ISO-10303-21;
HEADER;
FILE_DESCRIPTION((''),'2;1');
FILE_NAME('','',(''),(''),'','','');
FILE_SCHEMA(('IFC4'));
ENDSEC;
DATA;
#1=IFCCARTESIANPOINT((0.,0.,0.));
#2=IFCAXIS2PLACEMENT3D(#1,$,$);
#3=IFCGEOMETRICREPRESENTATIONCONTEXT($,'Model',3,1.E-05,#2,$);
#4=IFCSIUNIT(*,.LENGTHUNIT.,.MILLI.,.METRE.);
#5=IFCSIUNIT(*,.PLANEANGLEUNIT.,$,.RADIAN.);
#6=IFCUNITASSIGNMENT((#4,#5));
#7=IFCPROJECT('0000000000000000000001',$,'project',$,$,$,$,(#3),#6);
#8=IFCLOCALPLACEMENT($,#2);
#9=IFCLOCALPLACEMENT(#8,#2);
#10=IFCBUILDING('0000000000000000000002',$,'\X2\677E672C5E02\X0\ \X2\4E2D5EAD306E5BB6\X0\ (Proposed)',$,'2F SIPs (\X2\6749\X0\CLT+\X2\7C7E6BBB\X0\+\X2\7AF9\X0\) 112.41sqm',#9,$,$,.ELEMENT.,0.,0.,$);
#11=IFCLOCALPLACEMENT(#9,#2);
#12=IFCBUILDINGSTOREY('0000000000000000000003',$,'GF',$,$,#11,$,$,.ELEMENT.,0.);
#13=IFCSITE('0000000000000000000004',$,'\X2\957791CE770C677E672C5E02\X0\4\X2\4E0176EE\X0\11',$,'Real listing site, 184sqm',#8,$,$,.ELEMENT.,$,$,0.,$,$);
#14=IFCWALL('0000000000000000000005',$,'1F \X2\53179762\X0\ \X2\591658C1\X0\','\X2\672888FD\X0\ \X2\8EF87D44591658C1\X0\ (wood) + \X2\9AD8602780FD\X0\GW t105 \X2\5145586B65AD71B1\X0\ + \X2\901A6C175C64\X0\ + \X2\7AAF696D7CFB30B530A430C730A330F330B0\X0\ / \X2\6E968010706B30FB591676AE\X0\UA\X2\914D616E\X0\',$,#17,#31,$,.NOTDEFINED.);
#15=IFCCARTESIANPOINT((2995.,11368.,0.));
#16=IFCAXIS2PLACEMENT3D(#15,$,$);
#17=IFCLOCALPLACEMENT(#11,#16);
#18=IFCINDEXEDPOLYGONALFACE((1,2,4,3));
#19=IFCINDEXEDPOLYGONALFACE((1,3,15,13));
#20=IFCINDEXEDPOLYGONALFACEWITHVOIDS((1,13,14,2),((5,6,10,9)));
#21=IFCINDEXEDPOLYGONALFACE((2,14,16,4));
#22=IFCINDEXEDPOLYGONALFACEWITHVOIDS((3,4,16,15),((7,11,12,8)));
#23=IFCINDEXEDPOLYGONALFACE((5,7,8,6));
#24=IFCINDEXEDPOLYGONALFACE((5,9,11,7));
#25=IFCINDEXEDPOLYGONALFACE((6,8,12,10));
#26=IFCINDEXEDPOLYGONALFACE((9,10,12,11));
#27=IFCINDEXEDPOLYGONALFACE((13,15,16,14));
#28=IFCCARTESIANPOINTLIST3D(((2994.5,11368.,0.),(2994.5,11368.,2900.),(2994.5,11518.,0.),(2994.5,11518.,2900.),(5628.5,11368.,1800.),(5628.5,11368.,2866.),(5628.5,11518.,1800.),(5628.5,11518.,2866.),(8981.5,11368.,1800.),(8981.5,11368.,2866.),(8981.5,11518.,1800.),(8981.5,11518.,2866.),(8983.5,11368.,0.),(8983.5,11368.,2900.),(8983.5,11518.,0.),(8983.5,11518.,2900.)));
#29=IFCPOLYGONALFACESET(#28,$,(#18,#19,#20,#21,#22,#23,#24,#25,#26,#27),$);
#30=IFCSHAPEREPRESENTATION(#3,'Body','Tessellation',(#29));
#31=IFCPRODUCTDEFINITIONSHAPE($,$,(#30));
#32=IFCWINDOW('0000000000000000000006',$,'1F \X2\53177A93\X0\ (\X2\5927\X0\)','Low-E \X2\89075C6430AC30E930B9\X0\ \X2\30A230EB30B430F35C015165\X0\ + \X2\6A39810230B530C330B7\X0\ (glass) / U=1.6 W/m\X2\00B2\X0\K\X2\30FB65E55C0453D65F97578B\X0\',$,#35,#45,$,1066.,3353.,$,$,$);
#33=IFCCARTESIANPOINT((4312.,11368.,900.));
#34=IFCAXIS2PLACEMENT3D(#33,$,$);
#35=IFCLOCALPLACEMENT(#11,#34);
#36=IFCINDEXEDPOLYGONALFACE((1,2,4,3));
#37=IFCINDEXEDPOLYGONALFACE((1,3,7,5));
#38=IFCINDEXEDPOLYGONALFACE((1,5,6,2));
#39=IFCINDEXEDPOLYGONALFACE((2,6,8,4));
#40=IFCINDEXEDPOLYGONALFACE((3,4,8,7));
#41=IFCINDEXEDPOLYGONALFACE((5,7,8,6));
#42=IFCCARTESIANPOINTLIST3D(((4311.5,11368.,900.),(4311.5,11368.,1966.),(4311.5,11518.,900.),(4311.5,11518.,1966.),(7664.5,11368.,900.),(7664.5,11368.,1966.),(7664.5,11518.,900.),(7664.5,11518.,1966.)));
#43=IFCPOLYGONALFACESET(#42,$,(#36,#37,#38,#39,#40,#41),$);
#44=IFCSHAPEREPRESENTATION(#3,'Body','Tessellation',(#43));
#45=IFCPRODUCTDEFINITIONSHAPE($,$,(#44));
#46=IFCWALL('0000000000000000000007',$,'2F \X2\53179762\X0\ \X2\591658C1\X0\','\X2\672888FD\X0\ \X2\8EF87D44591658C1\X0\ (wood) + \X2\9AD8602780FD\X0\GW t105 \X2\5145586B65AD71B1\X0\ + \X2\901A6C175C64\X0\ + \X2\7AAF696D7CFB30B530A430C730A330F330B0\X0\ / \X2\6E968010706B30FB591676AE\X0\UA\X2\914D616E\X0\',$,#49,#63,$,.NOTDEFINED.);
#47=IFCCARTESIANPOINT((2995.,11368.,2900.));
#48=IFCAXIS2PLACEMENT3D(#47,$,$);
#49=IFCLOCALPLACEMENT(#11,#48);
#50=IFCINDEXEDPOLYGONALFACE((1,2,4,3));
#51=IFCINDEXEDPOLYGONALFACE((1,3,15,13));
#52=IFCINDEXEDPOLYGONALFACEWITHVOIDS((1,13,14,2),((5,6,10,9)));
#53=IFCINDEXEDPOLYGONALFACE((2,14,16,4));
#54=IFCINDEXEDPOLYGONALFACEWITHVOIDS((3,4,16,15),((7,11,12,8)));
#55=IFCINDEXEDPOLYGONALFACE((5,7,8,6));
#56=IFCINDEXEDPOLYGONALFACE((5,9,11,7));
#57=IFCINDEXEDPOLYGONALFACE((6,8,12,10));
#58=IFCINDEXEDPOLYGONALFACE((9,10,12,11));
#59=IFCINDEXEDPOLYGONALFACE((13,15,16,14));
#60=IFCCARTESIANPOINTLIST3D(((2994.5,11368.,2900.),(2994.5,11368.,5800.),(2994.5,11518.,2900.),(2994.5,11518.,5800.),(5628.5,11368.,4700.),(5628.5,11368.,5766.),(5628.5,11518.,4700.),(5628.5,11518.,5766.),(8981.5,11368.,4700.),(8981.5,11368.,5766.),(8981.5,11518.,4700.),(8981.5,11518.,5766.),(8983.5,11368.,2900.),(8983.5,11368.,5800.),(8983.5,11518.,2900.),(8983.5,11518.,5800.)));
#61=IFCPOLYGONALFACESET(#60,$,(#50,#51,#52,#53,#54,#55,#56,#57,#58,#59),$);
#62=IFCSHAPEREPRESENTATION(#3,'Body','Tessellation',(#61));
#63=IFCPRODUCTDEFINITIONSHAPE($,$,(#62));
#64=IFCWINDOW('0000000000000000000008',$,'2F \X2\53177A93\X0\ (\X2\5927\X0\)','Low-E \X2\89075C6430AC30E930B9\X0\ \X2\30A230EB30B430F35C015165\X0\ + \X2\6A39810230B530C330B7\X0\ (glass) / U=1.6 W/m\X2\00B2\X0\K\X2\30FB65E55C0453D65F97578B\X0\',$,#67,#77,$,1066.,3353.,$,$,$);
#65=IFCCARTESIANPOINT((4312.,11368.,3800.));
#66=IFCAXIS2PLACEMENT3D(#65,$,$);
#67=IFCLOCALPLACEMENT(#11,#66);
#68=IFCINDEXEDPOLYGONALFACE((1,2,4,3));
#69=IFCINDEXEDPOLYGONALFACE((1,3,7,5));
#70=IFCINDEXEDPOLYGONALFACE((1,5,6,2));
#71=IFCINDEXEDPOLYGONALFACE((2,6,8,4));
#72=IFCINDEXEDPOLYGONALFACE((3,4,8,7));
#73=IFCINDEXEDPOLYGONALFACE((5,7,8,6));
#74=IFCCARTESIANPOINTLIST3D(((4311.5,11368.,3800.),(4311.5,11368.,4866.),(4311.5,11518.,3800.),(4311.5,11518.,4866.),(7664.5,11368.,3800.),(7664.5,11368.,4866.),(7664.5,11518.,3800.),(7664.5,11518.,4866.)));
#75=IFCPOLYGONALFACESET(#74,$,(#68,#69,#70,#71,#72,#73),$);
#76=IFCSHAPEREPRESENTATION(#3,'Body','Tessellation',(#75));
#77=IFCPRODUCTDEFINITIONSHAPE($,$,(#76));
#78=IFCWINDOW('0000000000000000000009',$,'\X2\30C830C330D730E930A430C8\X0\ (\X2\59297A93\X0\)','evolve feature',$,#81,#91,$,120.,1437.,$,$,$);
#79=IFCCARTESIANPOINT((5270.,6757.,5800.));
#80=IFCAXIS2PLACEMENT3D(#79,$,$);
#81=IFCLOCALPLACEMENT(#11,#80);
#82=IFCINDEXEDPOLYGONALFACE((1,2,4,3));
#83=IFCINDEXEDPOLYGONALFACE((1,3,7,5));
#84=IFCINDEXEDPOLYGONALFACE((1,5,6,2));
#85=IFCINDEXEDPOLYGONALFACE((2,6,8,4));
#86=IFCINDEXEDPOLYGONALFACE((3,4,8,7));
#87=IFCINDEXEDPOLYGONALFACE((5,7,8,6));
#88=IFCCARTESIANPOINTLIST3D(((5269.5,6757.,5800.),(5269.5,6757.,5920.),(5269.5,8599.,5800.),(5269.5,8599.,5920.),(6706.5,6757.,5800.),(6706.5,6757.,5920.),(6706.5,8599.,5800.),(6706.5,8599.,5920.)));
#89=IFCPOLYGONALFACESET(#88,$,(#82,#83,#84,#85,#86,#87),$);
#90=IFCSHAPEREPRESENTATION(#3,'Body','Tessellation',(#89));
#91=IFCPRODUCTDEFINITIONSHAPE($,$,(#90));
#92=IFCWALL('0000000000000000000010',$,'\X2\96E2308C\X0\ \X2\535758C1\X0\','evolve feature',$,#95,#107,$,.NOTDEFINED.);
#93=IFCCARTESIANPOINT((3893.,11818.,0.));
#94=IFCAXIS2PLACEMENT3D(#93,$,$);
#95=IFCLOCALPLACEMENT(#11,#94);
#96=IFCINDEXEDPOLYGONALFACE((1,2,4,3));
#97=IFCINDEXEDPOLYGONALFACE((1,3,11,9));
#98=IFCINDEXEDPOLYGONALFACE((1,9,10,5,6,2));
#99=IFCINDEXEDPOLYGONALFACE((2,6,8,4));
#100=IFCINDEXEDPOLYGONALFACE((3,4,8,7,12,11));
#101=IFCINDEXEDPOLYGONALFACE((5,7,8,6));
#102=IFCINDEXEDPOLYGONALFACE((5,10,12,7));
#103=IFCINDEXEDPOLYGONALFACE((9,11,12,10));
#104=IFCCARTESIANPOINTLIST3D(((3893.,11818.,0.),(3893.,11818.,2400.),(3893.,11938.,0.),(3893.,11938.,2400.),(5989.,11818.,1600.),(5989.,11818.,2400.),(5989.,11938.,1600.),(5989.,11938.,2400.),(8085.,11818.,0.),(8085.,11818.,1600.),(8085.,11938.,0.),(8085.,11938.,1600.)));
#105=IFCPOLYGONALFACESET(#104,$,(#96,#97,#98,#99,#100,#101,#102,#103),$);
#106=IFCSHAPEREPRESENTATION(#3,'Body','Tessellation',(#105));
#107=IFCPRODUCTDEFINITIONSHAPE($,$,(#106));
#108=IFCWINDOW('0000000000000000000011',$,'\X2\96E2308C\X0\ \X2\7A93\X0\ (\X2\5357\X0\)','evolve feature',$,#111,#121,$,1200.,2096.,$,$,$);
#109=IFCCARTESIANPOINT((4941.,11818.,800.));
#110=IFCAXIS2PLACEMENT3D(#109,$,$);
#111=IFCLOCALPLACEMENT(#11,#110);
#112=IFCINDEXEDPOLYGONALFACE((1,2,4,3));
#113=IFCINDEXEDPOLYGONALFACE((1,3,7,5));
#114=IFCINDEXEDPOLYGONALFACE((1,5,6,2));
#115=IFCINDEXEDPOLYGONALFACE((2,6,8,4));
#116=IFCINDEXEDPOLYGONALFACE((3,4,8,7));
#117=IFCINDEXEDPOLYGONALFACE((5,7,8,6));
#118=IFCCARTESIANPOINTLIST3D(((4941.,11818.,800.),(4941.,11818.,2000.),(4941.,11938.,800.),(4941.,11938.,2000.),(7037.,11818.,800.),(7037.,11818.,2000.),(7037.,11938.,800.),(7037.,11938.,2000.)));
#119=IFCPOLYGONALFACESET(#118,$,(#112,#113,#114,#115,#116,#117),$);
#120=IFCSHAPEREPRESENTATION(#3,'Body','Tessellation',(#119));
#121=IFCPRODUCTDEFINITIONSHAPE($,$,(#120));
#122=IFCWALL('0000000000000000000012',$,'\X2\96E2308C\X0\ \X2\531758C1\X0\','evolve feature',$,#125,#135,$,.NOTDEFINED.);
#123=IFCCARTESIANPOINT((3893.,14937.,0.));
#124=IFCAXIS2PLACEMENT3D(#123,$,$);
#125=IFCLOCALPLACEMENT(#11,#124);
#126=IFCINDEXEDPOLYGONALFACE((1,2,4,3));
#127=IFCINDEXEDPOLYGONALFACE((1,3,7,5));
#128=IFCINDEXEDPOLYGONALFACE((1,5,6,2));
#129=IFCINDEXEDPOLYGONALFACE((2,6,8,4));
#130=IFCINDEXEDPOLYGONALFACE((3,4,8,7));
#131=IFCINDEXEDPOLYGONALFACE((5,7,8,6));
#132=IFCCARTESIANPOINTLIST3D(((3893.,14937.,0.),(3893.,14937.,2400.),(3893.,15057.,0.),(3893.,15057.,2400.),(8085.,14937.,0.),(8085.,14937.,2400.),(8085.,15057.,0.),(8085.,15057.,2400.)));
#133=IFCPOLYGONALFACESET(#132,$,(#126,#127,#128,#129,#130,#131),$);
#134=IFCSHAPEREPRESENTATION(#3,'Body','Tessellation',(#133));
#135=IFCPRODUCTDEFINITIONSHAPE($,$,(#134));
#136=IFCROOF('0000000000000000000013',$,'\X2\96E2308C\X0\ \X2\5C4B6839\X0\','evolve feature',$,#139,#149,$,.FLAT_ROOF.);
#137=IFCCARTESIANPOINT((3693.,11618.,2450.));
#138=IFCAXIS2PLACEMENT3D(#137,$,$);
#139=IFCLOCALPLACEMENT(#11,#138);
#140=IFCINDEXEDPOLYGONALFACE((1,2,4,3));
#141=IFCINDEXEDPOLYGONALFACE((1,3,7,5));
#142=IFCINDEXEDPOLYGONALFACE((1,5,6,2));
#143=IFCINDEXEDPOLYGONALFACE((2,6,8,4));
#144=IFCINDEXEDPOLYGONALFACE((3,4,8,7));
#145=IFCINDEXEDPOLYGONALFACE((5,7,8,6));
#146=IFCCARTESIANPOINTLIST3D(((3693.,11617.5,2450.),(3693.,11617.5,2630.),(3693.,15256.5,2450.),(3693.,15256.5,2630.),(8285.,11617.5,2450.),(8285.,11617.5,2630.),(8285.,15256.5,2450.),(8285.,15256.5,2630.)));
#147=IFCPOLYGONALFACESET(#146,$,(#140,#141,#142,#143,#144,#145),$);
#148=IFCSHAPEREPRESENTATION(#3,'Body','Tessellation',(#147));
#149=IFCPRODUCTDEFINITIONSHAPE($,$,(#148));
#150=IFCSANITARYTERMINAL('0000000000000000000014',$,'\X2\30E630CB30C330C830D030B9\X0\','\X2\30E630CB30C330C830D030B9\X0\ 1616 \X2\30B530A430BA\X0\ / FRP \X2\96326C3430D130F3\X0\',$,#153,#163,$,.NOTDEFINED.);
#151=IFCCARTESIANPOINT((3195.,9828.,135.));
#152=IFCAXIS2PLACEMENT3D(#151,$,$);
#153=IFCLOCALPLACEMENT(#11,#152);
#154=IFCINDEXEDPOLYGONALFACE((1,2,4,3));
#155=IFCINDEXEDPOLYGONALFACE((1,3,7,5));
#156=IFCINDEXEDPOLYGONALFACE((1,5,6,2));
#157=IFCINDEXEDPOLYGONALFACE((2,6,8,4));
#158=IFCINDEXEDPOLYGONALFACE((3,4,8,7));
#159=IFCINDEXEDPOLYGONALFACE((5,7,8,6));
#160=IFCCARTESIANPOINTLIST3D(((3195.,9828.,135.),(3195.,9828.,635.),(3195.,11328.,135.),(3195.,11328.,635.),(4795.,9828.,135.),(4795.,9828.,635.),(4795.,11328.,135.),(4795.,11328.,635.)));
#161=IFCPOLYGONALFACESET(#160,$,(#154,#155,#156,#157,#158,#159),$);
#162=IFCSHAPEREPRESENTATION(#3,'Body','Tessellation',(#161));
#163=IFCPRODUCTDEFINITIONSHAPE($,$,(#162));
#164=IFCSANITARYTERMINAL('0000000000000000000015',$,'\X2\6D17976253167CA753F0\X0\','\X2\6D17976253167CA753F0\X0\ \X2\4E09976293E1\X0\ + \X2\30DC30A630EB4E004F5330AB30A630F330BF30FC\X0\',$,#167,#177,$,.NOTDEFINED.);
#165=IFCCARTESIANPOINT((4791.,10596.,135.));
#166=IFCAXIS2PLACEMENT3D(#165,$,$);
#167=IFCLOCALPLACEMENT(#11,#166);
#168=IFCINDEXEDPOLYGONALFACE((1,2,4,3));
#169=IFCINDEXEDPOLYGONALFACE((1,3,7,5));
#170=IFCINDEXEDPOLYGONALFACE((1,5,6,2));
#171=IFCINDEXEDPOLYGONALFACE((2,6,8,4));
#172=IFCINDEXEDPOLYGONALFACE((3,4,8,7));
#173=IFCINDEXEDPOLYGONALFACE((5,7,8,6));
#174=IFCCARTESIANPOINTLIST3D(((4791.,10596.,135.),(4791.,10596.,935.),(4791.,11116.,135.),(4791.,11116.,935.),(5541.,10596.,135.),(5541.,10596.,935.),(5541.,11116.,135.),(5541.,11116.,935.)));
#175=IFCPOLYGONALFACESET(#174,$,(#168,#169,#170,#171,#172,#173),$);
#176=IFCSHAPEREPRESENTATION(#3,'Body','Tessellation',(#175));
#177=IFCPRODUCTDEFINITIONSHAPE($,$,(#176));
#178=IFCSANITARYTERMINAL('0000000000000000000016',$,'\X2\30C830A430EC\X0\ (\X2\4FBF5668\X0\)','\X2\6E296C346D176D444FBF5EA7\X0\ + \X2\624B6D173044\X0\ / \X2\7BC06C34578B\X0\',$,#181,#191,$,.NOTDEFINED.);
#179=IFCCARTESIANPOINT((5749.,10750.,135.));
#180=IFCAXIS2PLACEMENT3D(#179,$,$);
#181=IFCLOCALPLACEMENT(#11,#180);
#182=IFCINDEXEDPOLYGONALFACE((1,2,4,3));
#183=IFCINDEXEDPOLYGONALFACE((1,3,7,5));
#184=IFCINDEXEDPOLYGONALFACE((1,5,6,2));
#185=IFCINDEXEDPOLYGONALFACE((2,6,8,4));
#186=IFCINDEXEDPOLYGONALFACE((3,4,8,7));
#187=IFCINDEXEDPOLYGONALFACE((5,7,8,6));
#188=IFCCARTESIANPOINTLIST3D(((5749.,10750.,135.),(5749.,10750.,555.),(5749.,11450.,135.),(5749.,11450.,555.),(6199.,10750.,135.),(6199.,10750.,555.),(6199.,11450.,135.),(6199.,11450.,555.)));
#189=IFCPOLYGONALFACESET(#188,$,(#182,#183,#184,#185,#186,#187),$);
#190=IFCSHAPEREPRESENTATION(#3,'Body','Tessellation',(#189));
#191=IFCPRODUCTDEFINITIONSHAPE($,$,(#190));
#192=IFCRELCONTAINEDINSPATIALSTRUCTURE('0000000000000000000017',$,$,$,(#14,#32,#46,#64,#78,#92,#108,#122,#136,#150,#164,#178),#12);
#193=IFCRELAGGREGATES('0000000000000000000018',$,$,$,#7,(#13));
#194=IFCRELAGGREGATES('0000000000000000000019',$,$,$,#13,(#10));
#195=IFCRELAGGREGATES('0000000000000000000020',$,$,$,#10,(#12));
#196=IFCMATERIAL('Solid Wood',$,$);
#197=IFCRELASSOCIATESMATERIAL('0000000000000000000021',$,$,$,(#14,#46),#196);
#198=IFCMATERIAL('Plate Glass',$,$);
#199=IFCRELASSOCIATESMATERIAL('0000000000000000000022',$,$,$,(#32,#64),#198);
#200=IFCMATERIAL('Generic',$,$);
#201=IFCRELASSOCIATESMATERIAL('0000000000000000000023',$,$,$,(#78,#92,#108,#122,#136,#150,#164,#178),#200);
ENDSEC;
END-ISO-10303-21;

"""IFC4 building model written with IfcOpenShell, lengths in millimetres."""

from ifc_helpers import new_model, si_unit, frame, frame_2d, origin, place, context, project, spatial, rectangle, extrude, material, element, fill, save


model = new_model("IFC4")

# Units and contexts
model_context = context("Model", 3, precision=1e-05, world=origin())
ifc_project = project(units=[si_unit("LENGTHUNIT", "METRE", prefix="MILLI"), si_unit("PLANEANGLEUNIT", "RADIAN")], contexts=[model_context])

# Site, building, storey
site_placement = place(None, origin())
site = spatial("IfcSite", under=ifc_project, at=site_placement, Name="長野県松本市4丁目11", ObjectType="Real listing site, 184sqm", CompositionType="ELEMENT", RefElevation=0.0)
building_placement = place(site_placement, origin())
building = spatial("IfcBuilding", under=site, at=building_placement, Name="松本市 中庭の家 (Proposed)", ObjectType="2F SIPs (杉CLT+籾殻+竹) 112.41sqm", CompositionType="ELEMENT", ElevationOfRefHeight=0.0, ElevationOfTerrain=0.0)
storey_placement = place(building_placement, origin())
storey = spatial("IfcBuildingStorey", under=building, at=storey_placement, Name="GF", CompositionType="ELEMENT", Elevation=0.0)

# Shared definitions
ifc_material_1 = material(Name="Generic")

# Wall, opening, window
ifc_material_2 = material(Name="Solid Wood")
wall_1_placement = place(storey_placement, frame((2995.0, 11368.0, 0.0)))
wall_1 = element("IfcWall", 1, at=wall_1_placement, inside=storey, material=ifc_material_2, Name="1F 北面 外壁", Description="木製 軸組外壁 (wood) + 高性能GW t105 充填断熱 + 通気層 + 窯業系サイディング / 準耐火・外皮UA配慮", PredefinedType="NOTDEFINED", context=model_context, shape_type="SweptSolid", body=[
    extrude(rectangle(XDim=5989.0, YDim=150.0, at=frame_2d((2994.0, 75.0))), frame((2995.0, 11368.0, 0.0)), (0.0, 0.0, 1.0), 2900.0),
])
opening_1_placement = place(storey_placement, frame((4312.0, 11368.0, 900.0)))
opening_1 = element("IfcOpeningElement", 2, at=opening_1_placement, cuts=wall_1, PredefinedType="NOTDEFINED", context=model_context, shape_type="SweptSolid", body=[
    extrude(rectangle(XDim=3353.0, YDim=150.0, at=frame_2d((1676.0, 75.0))), frame((4312.0, 11368.0, 900.0)), (0.0, 0.0, 1.0), 1066.0),
])
ifc_material_3 = material(Name="Plate Glass")
window_1_placement = place(storey_placement, frame((4312.0, 11368.0, 900.0)))
window_1 = element("IfcWindow", 3, at=window_1_placement, inside=storey, material=ifc_material_3, Name="1F 北窓 (大)", Description="Low-E 複層ガラス アルゴン封入 + 樹脂サッシ (glass) / U=1.6 W/m²K・日射取得型", OverallHeight=1066.0, OverallWidth=3353.0, context=model_context, shape_type="SweptSolid", body=[
    extrude(rectangle(XDim=3353.0, YDim=150.0, at=frame_2d((1676.0, 75.0))), frame((4312.0, 11368.0, 900.0)), (0.0, 0.0, 1.0), 1066.0),
])
fill(opening_1, window_1)

# Wall, opening, window
wall_2_placement = place(storey_placement, frame((2995.0, 11368.0, 2900.0)))
wall_2 = element("IfcWall", 4, at=wall_2_placement, inside=storey, material=ifc_material_2, Name="2F 北面 外壁", Description="木製 軸組外壁 (wood) + 高性能GW t105 充填断熱 + 通気層 + 窯業系サイディング / 準耐火・外皮UA配慮", PredefinedType="NOTDEFINED", context=model_context, shape_type="SweptSolid", body=[
    extrude(rectangle(XDim=5989.0, YDim=150.0, at=frame_2d((2994.0, 75.0))), frame((2995.0, 11368.0, 2900.0)), (0.0, 0.0, 1.0), 2900.0),
])
opening_2_placement = place(storey_placement, frame((4312.0, 11368.0, 3800.0)))
opening_2 = element("IfcOpeningElement", 5, at=opening_2_placement, cuts=wall_2, PredefinedType="NOTDEFINED", context=model_context, shape_type="SweptSolid", body=[
    extrude(rectangle(XDim=3353.0, YDim=150.0, at=frame_2d((1676.0, 75.0))), frame((4312.0, 11368.0, 3800.0)), (0.0, 0.0, 1.0), 1066.0),
])
window_2_placement = place(storey_placement, frame((4312.0, 11368.0, 3800.0)))
window_2 = element("IfcWindow", 6, at=window_2_placement, inside=storey, material=ifc_material_3, Name="2F 北窓 (大)", Description="Low-E 複層ガラス アルゴン封入 + 樹脂サッシ (glass) / U=1.6 W/m²K・日射取得型", OverallHeight=1066.0, OverallWidth=3353.0, context=model_context, shape_type="SweptSolid", body=[
    extrude(rectangle(XDim=3353.0, YDim=150.0, at=frame_2d((1676.0, 75.0))), frame((4312.0, 11368.0, 3800.0)), (0.0, 0.0, 1.0), 1066.0),
])
fill(opening_2, window_2)

# Window
window_3_placement = place(storey_placement, frame((5270.0, 6757.0, 5800.0)))
element("IfcWindow", 7, at=window_3_placement, inside=storey, material=ifc_material_1, Name="トップライト (天窓)", Description="evolve feature", OverallHeight=120.0, OverallWidth=1437.0, context=model_context, shape_type="SweptSolid", body=[
    extrude(rectangle(XDim=1437.0, YDim=1842.0, at=frame_2d((718.0, 921.0))), frame((5270.0, 6757.0, 5800.0)), (0.0, 0.0, 1.0), 120.0),
])

# Wall, opening, window
wall_3_placement = place(storey_placement, frame((3893.0, 11818.0, 0.0)))
wall_3 = element("IfcWall", 8, at=wall_3_placement, inside=storey, material=ifc_material_1, Name="離れ 南壁", Description="evolve feature", PredefinedType="NOTDEFINED", context=model_context, shape_type="SweptSolid", body=[
    extrude(rectangle(XDim=4192.0, YDim=120.0, at=frame_2d((2096.0, 60.0))), frame((3893.0, 11818.0, 0.0)), (0.0, 0.0, 1.0), 2400.0),
])
opening_3_placement = place(storey_placement, frame((4941.0, 11818.0, 800.0)))
opening_3 = element("IfcOpeningElement", 9, at=opening_3_placement, cuts=wall_3, PredefinedType="NOTDEFINED", context=model_context, shape_type="SweptSolid", body=[
    extrude(rectangle(XDim=2096.0, YDim=120.0, at=frame_2d((1048.0, 60.0))), frame((4941.0, 11818.0, 800.0)), (0.0, 0.0, 1.0), 1200.0),
])
window_4_placement = place(storey_placement, frame((4941.0, 11818.0, 800.0)))
window_4 = element("IfcWindow", 10, at=window_4_placement, inside=storey, material=ifc_material_1, Name="離れ 窓 (南)", Description="evolve feature", OverallHeight=1200.0, OverallWidth=2096.0, context=model_context, shape_type="SweptSolid", body=[
    extrude(rectangle(XDim=2096.0, YDim=120.0, at=frame_2d((1048.0, 60.0))), frame((4941.0, 11818.0, 800.0)), (0.0, 0.0, 1.0), 1200.0),
])
fill(opening_3, window_4)

# Wall
wall_4_placement = place(storey_placement, frame((3893.0, 14937.0, 0.0)))
element("IfcWall", 11, at=wall_4_placement, inside=storey, material=ifc_material_1, Name="離れ 北壁", Description="evolve feature", PredefinedType="NOTDEFINED", context=model_context, shape_type="SweptSolid", body=[
    extrude(rectangle(XDim=4192.0, YDim=120.0, at=frame_2d((2096.0, 60.0))), frame((3893.0, 14937.0, 0.0)), (0.0, 0.0, 1.0), 2400.0),
])

# Roof
roof_1_placement = place(storey_placement, frame((3693.0, 11618.0, 2450.0)))
element("IfcRoof", 12, at=roof_1_placement, inside=storey, material=ifc_material_1, Name="離れ 屋根", Description="evolve feature", PredefinedType="FLAT_ROOF", context=model_context, shape_type="SweptSolid", body=[
    extrude(rectangle(XDim=4592.0, YDim=3639.0, at=frame_2d((2296.0, 1819.0))), frame((3693.0, 11618.0, 2450.0)), (0.0, 0.0, 1.0), 180.0),
])

# Sanitary terminals
sanitary_terminal_1_placement = place(storey_placement, frame((3195.0, 9828.0, 135.0)))
element("IfcSanitaryTerminal", 13, at=sanitary_terminal_1_placement, inside=storey, material=ifc_material_1, Name="ユニットバス", Description="ユニットバス 1616 サイズ / FRP 防水パン", PredefinedType="NOTDEFINED", context=model_context, shape_type="SweptSolid", body=[
    extrude(rectangle(XDim=1600.0, YDim=1500.0, at=frame_2d((800.0, 750.0))), frame((3195.0, 9828.0, 135.0)), (0.0, 0.0, 1.0), 500.0),
])
sanitary_terminal_2_placement = place(storey_placement, frame((4791.0, 10596.0, 135.0)))
element("IfcSanitaryTerminal", 14, at=sanitary_terminal_2_placement, inside=storey, material=ifc_material_1, Name="洗面化粧台", Description="洗面化粧台 三面鏡 + ボウル一体カウンター", PredefinedType="NOTDEFINED", context=model_context, shape_type="SweptSolid", body=[
    extrude(rectangle(XDim=750.0, YDim=520.0, at=frame_2d((375.0, 260.0))), frame((4791.0, 10596.0, 135.0)), (0.0, 0.0, 1.0), 800.0),
])
sanitary_terminal_3_placement = place(storey_placement, frame((5749.0, 10750.0, 135.0)))
element("IfcSanitaryTerminal", 15, at=sanitary_terminal_3_placement, inside=storey, material=ifc_material_1, Name="トイレ (便器)", Description="温水洗浄便座 + 手洗い / 節水型", PredefinedType="NOTDEFINED", context=model_context, shape_type="SweptSolid", body=[
    extrude(rectangle(XDim=450.0, YDim=700.0, at=frame_2d((225.0, 350.0))), frame((5749.0, 10750.0, 135.0)), (0.0, 0.0, 1.0), 420.0),
])

save(model, "model.ifc")
